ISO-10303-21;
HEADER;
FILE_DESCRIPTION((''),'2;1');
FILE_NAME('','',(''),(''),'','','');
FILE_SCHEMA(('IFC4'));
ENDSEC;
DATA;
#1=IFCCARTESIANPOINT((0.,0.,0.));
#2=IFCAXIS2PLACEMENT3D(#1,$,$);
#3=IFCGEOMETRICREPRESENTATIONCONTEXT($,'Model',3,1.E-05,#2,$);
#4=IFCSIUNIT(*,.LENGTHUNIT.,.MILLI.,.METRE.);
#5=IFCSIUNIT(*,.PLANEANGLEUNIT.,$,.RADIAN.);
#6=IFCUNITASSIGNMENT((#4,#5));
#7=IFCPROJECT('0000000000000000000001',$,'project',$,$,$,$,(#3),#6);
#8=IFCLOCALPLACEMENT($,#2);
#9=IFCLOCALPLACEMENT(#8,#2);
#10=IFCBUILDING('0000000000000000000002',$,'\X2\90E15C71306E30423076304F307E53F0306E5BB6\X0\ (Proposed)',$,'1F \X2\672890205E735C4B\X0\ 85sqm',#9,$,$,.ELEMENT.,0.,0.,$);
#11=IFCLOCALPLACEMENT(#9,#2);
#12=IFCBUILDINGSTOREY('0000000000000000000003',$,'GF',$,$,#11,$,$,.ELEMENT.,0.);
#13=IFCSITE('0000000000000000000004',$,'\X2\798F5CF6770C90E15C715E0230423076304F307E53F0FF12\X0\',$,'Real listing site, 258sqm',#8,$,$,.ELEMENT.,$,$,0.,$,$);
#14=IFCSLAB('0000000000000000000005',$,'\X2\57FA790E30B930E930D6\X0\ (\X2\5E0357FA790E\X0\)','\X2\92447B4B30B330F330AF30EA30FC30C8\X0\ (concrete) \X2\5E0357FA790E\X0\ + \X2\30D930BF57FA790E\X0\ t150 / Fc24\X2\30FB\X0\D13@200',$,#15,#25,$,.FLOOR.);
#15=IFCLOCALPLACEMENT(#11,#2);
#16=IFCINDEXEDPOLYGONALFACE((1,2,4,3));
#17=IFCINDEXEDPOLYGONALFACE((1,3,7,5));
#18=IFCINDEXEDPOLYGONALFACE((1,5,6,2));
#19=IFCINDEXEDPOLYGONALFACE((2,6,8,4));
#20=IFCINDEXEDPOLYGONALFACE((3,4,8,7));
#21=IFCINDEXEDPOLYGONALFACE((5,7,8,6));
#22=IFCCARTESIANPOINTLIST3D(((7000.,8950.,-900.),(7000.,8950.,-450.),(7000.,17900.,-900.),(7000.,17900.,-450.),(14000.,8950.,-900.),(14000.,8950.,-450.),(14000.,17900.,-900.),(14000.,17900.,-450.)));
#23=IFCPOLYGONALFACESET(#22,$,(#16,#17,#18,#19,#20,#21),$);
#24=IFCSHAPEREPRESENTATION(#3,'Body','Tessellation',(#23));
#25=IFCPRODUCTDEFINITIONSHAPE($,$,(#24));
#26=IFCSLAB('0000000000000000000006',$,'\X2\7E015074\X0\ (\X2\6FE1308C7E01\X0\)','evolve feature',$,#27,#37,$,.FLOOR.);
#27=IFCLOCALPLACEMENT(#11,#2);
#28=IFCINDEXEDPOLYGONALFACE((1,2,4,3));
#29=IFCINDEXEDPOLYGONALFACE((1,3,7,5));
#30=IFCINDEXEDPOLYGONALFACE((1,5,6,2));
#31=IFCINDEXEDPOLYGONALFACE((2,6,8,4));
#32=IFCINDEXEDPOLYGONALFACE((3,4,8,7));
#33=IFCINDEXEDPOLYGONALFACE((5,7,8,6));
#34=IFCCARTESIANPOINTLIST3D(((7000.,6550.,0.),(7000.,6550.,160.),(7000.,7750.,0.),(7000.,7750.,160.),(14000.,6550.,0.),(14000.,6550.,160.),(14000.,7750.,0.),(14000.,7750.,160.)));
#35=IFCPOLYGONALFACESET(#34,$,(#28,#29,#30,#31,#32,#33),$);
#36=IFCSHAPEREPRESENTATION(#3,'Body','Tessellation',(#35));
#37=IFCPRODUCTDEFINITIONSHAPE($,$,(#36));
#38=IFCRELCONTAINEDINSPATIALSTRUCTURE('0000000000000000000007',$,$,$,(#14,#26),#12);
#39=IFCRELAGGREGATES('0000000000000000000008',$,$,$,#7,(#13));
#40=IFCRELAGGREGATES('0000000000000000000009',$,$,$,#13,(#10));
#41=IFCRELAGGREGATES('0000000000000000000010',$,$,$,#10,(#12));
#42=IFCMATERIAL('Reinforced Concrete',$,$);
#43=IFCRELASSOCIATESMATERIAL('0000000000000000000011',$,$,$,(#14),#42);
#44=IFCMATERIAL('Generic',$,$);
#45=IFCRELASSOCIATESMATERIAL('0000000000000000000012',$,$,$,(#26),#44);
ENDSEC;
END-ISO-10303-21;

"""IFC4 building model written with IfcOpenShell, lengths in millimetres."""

from ifc_helpers import new_model, si_unit, frame, frame_2d, origin, place, context, project, spatial, rectangle, extrude, material, element, save


model = new_model("IFC4")

# Units and contexts
model_context = context("Model", 3, precision=1e-05, world=origin())
ifc_project = project(units=[si_unit("LENGTHUNIT", "METRE", prefix="MILLI"), si_unit("PLANEANGLEUNIT", "RADIAN")], contexts=[model_context])

# Site, building, storey
site_placement = place(None, origin())
site = spatial("IfcSite", under=ifc_project, at=site_placement, Name="福島県郡山市あぶくま台２", ObjectType="Real listing site, 258sqm", CompositionType="ELEMENT", RefElevation=0.0)
building_placement = place(site_placement, origin())
building = spatial("IfcBuilding", under=site, at=building_placement, Name="郡山のあぶくま台の家 (Proposed)", ObjectType="1F 木造平屋 85sqm", CompositionType="ELEMENT", ElevationOfRefHeight=0.0, ElevationOfTerrain=0.0)
storey_placement = place(building_placement, origin())
storey = spatial("IfcBuildingStorey", under=building, at=storey_placement, Name="GF", CompositionType="ELEMENT", Elevation=0.0)

# Slabs
ifc_material_1 = material(Name="Reinforced Concrete")
slab_1_placement = place(storey_placement, frame((3500.0, 4475.0, -450.0)))
element("IfcSlab", 1, at=slab_1_placement, inside=storey, material=ifc_material_1, Name="基礎スラブ (布基礎)", Description="鉄筋コンクリート (concrete) 布基礎 + ベタ基礎 t150 / Fc24・D13@200", PredefinedType="FLOOR", context=model_context, shape_type="SweptSolid", body=[
    extrude(rectangle(XDim=7000.0, YDim=8950.0, at=frame_2d((3500.0, 4475.0))), frame((3500.0, 4475.0, -450.0)), (0.0, 0.0, 1.0), 450.0),
])
ifc_material_2 = material(Name="Generic")
slab_2_placement = place(storey_placement, frame((3500.0, 3275.0, 0.0)))
element("IfcSlab", 2, at=slab_2_placement, inside=storey, material=ifc_material_2, Name="縁側 (濡れ縁)", Description="evolve feature", PredefinedType="FLOOR", context=model_context, shape_type="SweptSolid", body=[
    extrude(rectangle(XDim=7000.0, YDim=1200.0, at=frame_2d((3500.0, 600.0))), frame((3500.0, 3275.0, 0.0)), (0.0, 0.0, 1.0), 160.0),
])

save(model, "model.ifc")
